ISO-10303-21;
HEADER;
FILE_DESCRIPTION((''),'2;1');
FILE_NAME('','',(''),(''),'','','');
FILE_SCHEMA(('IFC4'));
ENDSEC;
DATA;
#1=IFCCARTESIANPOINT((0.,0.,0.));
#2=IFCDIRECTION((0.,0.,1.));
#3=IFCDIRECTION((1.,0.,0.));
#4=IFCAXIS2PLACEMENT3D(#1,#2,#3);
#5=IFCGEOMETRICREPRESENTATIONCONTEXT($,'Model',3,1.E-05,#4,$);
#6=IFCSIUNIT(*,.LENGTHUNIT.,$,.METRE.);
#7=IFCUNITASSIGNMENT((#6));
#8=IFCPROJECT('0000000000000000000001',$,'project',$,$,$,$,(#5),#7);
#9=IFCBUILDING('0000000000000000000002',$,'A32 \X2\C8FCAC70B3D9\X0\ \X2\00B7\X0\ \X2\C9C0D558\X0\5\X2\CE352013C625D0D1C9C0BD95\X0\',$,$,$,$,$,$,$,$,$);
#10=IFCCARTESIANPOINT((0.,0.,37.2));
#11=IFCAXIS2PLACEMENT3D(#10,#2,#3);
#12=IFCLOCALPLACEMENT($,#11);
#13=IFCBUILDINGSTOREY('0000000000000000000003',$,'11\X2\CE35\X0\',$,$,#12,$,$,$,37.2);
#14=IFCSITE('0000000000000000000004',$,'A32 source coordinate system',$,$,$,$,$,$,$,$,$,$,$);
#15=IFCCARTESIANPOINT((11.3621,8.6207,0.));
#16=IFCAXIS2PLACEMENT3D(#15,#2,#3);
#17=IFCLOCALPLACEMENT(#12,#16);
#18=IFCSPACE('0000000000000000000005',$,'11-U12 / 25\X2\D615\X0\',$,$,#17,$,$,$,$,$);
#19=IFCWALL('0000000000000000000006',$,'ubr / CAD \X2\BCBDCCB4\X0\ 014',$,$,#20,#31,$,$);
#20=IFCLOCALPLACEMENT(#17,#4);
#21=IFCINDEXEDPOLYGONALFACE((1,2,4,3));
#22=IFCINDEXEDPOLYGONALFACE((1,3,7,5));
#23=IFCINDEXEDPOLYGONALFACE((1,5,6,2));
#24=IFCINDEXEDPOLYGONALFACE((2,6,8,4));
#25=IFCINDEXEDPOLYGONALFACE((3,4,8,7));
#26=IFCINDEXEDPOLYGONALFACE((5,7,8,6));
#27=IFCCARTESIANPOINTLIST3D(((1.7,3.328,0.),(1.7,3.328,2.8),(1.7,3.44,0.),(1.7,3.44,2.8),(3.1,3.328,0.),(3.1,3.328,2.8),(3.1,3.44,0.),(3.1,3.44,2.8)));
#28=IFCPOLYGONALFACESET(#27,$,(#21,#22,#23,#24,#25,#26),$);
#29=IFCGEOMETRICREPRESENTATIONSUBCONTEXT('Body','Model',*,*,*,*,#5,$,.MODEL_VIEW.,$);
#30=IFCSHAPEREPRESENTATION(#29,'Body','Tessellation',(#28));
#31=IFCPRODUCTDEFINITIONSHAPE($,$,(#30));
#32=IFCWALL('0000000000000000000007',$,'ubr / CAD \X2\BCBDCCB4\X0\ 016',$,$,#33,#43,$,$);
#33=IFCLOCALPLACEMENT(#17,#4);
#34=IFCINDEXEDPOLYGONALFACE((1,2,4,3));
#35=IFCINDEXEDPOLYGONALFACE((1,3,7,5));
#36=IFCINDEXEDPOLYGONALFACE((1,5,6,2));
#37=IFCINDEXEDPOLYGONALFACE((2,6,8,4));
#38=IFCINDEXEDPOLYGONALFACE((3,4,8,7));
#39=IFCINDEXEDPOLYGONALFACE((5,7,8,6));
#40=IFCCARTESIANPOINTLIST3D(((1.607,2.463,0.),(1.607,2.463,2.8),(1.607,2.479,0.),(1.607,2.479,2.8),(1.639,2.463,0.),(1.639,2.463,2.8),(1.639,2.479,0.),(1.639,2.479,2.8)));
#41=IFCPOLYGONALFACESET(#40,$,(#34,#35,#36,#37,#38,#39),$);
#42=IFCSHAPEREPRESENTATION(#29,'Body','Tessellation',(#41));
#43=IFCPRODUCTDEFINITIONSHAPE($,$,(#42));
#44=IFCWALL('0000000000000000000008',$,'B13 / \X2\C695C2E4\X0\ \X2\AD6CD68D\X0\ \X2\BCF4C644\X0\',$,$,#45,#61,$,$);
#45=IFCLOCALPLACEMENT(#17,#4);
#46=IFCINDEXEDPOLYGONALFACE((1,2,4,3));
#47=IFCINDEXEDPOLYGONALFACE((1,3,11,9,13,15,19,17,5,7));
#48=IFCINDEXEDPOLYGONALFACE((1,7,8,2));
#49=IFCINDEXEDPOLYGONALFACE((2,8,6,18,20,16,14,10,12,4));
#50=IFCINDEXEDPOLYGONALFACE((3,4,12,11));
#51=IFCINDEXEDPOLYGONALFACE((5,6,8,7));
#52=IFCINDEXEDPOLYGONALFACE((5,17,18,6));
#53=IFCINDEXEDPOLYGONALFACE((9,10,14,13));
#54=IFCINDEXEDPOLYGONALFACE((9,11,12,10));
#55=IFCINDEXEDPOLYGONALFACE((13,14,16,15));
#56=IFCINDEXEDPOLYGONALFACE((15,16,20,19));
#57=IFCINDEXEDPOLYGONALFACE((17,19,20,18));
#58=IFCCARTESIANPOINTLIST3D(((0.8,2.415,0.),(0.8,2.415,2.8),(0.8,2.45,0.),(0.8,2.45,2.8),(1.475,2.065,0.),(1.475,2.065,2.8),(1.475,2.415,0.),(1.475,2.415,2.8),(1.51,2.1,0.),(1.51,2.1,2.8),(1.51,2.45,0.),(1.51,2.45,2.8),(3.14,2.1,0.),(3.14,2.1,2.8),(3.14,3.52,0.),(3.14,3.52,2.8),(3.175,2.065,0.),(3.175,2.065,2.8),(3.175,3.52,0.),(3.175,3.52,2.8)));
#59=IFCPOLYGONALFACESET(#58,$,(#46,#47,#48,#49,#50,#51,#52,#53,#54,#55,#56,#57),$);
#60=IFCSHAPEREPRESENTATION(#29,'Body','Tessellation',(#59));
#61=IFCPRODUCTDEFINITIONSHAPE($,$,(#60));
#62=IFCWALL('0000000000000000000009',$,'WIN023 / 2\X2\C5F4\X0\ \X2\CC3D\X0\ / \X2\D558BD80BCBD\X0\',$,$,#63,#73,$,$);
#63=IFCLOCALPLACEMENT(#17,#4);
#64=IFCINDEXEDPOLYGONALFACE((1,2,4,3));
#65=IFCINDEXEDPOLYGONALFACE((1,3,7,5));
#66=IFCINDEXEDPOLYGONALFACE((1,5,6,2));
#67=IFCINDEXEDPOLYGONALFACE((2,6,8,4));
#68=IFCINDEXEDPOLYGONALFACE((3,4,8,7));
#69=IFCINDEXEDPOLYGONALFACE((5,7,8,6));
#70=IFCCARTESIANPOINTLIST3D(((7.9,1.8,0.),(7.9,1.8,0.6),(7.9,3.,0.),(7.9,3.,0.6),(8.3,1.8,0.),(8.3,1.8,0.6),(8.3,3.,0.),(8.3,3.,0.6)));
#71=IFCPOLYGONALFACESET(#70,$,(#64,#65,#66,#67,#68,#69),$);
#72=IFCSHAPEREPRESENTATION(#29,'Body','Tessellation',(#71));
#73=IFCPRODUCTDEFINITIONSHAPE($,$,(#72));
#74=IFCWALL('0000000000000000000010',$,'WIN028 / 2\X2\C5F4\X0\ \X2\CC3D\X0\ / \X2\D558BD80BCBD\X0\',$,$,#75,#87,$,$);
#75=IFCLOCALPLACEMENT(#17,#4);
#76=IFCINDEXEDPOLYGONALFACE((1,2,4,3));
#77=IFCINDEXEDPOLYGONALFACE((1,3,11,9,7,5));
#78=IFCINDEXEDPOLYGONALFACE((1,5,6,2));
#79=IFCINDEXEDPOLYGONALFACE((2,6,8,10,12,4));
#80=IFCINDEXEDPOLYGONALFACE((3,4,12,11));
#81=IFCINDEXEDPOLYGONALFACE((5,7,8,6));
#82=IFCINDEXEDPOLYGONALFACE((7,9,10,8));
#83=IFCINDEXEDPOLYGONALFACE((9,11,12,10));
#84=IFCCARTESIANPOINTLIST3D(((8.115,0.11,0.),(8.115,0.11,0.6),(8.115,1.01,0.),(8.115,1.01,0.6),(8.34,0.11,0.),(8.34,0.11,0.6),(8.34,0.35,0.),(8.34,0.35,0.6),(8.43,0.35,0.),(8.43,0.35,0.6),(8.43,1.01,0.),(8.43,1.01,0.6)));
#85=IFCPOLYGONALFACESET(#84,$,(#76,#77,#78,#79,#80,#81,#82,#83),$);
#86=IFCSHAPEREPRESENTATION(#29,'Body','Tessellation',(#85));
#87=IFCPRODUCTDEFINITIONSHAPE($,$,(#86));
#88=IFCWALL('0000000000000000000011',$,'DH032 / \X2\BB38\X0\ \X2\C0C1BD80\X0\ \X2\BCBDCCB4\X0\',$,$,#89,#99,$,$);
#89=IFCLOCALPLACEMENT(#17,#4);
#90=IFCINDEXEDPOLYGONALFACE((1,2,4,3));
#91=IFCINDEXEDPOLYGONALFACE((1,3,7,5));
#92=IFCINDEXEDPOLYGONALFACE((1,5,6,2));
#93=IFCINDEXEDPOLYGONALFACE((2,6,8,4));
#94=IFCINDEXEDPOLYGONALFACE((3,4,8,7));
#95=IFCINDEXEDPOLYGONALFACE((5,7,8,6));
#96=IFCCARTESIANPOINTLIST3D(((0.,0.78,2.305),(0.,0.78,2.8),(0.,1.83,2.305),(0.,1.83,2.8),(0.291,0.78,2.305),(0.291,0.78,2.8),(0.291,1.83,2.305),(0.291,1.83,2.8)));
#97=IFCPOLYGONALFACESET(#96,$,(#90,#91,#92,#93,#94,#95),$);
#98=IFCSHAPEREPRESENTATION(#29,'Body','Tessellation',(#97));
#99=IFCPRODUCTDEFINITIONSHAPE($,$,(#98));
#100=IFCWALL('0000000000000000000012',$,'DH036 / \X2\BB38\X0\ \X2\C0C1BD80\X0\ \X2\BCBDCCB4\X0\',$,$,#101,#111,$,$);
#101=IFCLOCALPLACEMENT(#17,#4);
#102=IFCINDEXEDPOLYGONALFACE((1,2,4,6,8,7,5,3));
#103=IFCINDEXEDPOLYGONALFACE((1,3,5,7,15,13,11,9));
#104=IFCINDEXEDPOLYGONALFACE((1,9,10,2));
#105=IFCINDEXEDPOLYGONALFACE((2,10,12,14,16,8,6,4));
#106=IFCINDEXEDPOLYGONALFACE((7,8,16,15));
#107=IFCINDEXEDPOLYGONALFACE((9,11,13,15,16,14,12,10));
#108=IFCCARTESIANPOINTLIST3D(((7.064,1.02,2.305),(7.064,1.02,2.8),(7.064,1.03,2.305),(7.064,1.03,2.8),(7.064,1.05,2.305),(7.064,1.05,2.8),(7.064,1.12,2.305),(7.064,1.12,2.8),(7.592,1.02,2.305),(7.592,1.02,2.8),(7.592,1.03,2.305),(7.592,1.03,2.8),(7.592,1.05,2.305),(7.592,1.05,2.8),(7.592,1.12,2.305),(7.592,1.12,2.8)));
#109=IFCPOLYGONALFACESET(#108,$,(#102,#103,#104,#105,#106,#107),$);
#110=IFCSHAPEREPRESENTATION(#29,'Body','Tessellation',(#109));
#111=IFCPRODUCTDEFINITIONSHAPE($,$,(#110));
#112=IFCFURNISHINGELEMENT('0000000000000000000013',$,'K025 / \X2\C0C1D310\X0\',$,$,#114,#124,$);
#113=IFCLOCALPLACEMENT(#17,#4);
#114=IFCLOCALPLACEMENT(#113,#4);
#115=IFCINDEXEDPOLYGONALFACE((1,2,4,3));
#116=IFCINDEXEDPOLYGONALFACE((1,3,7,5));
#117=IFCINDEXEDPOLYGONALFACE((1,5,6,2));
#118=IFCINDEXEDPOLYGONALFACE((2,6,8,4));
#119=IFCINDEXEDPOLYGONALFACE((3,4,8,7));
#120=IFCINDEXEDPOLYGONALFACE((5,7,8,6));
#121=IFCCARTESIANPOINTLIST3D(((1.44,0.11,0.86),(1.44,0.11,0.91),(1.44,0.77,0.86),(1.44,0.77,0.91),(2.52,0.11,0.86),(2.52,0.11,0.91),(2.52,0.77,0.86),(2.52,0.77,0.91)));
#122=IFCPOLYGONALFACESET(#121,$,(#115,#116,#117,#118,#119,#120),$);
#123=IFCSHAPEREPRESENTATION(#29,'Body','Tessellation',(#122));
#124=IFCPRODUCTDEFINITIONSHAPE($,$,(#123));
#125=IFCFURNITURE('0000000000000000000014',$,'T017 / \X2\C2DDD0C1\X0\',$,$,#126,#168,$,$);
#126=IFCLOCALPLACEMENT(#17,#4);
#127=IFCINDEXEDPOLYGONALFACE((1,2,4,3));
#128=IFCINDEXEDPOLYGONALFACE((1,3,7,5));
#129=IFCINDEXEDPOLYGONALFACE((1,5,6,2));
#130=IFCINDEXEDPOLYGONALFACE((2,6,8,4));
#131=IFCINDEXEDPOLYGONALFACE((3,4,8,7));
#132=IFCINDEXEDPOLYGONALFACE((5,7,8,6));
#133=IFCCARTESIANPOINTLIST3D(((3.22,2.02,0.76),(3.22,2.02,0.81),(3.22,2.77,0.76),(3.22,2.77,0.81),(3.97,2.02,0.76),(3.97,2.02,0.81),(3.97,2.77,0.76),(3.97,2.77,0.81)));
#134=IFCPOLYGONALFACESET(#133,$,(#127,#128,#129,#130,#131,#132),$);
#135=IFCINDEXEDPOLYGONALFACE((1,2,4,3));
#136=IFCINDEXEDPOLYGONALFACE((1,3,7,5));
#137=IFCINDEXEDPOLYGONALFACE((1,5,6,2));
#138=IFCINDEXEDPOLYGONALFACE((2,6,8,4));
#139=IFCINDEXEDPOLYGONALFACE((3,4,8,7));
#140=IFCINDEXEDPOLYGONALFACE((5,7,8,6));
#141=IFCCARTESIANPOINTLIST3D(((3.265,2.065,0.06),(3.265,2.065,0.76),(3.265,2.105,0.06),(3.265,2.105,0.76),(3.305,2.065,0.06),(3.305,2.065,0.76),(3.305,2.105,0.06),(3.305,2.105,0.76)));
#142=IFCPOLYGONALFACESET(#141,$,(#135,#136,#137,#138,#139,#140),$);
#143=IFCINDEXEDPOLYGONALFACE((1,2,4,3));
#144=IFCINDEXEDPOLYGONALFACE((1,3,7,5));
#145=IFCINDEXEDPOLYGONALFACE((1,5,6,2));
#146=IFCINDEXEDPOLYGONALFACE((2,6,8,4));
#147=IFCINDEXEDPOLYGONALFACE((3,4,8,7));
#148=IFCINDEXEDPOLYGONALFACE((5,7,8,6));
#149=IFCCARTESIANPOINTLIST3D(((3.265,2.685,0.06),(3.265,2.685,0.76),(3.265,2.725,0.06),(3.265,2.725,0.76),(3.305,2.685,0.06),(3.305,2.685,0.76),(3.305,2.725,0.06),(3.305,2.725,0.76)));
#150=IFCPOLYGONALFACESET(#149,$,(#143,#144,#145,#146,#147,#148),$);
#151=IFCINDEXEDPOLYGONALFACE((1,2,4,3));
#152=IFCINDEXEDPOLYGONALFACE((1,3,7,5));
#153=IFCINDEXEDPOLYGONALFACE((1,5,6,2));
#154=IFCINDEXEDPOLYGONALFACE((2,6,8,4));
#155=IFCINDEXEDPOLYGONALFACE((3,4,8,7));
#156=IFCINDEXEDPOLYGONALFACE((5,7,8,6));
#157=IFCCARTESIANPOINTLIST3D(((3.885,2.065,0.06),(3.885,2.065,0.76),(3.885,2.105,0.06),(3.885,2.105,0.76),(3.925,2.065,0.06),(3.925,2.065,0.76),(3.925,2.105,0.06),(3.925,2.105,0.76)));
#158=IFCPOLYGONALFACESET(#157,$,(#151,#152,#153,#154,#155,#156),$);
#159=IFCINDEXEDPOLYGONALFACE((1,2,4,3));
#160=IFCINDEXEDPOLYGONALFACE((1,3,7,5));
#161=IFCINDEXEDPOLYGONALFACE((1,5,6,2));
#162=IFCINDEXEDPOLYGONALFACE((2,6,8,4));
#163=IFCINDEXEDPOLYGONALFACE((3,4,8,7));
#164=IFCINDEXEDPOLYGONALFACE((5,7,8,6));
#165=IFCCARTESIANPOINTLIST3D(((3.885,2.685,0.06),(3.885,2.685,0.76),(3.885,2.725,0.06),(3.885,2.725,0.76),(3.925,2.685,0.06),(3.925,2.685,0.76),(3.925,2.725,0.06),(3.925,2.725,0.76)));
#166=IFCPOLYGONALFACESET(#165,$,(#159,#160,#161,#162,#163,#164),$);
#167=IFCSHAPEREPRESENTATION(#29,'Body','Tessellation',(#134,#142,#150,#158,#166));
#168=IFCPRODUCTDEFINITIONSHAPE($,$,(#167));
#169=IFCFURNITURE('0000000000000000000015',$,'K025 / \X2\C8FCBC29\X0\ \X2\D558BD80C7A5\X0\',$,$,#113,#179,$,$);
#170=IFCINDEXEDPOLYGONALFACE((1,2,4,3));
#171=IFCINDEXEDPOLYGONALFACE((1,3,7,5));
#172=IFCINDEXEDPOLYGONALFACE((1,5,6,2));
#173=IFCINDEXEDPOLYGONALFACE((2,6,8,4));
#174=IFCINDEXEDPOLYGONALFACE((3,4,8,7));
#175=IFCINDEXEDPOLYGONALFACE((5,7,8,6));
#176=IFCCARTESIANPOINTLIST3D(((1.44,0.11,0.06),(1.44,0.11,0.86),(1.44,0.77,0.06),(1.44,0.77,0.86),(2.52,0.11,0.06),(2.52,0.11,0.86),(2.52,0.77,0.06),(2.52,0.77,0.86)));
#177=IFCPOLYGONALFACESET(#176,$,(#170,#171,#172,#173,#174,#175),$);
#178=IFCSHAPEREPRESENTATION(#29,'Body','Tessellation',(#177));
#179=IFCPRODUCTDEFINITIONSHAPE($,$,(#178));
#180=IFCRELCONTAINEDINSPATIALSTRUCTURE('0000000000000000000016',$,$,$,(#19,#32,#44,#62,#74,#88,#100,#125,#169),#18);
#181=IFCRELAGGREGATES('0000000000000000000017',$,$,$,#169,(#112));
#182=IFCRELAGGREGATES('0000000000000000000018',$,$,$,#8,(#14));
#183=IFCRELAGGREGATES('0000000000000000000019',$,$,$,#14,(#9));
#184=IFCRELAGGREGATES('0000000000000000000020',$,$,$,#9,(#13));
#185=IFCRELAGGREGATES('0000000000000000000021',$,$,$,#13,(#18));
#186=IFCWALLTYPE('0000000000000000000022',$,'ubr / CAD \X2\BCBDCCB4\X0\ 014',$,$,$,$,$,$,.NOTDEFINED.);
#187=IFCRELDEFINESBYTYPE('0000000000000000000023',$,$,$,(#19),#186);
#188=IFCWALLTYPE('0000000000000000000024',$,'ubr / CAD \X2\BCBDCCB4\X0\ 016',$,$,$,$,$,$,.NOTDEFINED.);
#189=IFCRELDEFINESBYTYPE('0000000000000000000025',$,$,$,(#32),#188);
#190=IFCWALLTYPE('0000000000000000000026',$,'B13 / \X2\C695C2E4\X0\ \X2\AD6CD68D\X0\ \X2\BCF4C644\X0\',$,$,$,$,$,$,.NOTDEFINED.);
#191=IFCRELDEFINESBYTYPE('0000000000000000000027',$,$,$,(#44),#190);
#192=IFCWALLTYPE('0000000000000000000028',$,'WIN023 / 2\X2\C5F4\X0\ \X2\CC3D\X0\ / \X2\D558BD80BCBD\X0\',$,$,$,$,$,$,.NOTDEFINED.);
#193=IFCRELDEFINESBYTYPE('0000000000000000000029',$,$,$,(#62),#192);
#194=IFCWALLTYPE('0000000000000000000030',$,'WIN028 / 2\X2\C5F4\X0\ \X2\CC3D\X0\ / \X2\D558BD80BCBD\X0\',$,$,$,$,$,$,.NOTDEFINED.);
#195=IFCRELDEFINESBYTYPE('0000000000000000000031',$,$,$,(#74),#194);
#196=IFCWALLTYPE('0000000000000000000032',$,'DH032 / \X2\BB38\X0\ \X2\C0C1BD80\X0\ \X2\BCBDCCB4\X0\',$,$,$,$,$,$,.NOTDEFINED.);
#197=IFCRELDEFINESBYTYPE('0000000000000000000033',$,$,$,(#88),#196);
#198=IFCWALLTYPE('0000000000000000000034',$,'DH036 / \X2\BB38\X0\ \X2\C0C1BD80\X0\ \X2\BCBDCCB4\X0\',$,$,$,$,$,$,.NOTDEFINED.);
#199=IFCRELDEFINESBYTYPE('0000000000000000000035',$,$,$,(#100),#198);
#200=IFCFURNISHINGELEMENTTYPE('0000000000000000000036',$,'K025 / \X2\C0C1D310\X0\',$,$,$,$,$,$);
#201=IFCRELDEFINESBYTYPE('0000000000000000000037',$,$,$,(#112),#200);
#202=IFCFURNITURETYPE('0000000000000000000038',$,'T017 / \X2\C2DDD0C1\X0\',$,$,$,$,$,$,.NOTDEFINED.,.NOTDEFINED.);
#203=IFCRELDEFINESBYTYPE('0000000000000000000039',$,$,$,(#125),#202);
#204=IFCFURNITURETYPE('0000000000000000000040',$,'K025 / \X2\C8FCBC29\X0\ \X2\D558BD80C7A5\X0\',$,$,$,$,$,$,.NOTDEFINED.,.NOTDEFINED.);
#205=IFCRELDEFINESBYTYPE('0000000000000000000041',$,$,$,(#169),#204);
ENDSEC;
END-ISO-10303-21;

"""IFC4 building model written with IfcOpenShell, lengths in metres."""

from ifc_helpers import new_model, si_unit, frame, origin, origin_with_axes, place, context, subcontext, project, spatial, polyline, outline, extrude, source, transform, mapped, type_object, type_shapes, element, aggregate, save


model = new_model("IFC4")

# Units and contexts
model_context = context("Model", 3, precision=1e-05, world=origin_with_axes())
body_context = subcontext(model_context, "Body", "Model", "MODEL_VIEW")
ifc_project = project(units=[si_unit("LENGTHUNIT", "METRE")], contexts=[model_context])

# Site, building, storey, space
site = spatial("IfcSite", under=ifc_project, Name="A32 source coordinate system")
building = spatial("IfcBuilding", under=site, Name="A32 주거동 · 지하5층–옥탑지붕")
storey_placement = place(None, frame((0.0, 0.0, 37.2), z_axis=(0.0, 0.0, 1.0), x_axis=(1.0, 0.0, 0.0)))
storey = spatial("IfcBuildingStorey", under=building, at=storey_placement, Name="11층", Elevation=37.2)
space_1_placement = place(storey_placement, frame((11.3621, 8.6207, 0.0), z_axis=(0.0, 0.0, 1.0), x_axis=(1.0, 0.0, 0.0)))
space_1 = spatial("IfcSpace", under=storey, at=space_1_placement, Name="11-U12 / 25형")

# Walls
wall_type_1 = type_object("IfcWallType", Name="ubr / CAD 벽체 014", PredefinedType="NOTDEFINED")
shared_shape_1 = source(origin(), body_context, "Body", "SweptSolid", [
    extrude(outline(polyline([(3.1, 3.44), (3.1, 3.328), (1.7, 3.328), (1.7, 3.44), (3.1, 3.44)])), origin(), (0.0, 0.0, 1.0), 2.8),
])
type_shapes(wall_type_1, [shared_shape_1])
wall_1_placement = place(space_1_placement, origin_with_axes())
element("IfcWall", 1, at=wall_1_placement, inside=space_1, type_object=wall_type_1, Name="ubr / CAD 벽체 014", context=body_context, shape_type="MappedRepresentation", body=[
    mapped(shared_shape_1, transform((0.0, 0.0, 0.0), scale=1.0)),
])
wall_type_2 = type_object("IfcWallType", Name="ubr / CAD 벽체 016", PredefinedType="NOTDEFINED")
shared_shape_2 = source(origin(), body_context, "Body", "SweptSolid", [
    extrude(outline(polyline([(1.639, 2.479), (1.639, 2.463), (1.607, 2.463), (1.607, 2.479), (1.639, 2.479)])), origin(), (0.0, 0.0, 1.0), 2.8),
])
type_shapes(wall_type_2, [shared_shape_2])
wall_2_placement = place(space_1_placement, origin_with_axes())
element("IfcWall", 2, at=wall_2_placement, inside=space_1, type_object=wall_type_2, Name="ubr / CAD 벽체 016", context=body_context, shape_type="MappedRepresentation", body=[
    mapped(shared_shape_2, transform((0.0, 0.0, 0.0), scale=1.0)),
])
wall_type_3 = type_object("IfcWallType", Name="B13 / 욕실 구획 보완", PredefinedType="NOTDEFINED")
shared_shape_3 = source(origin(), body_context, "Body", "SweptSolid", [
    extrude(outline(polyline([(0.8, 2.45), (1.51, 2.45), (1.51, 2.1), (3.14, 2.1), (3.14, 3.52), (3.175, 3.52), (3.175, 2.065), (1.475, 2.065), (1.475, 2.415), (0.8, 2.415), (0.8, 2.45)])), origin(), (0.0, 0.0, 1.0), 2.8),
])
type_shapes(wall_type_3, [shared_shape_3])
wall_3_placement = place(space_1_placement, origin_with_axes())
element("IfcWall", 3, at=wall_3_placement, inside=space_1, type_object=wall_type_3, Name="B13 / 욕실 구획 보완", context=body_context, shape_type="MappedRepresentation", body=[
    mapped(shared_shape_3, transform((0.0, 0.0, 0.0), scale=1.0)),
])
wall_type_4 = type_object("IfcWallType", Name="WIN023 / 2열 창 / 하부벽", PredefinedType="NOTDEFINED")
shared_shape_4 = source(origin(), body_context, "Body", "SweptSolid", [
    extrude(outline(polyline([(7.9, 1.8), (7.9, 3.0), (8.3, 3.0), (8.3, 1.8), (7.9, 1.8)])), origin(), (0.0, 0.0, 1.0), 0.6),
])
type_shapes(wall_type_4, [shared_shape_4])
wall_4_placement = place(space_1_placement, origin_with_axes())
element("IfcWall", 4, at=wall_4_placement, inside=space_1, type_object=wall_type_4, Name="WIN023 / 2열 창 / 하부벽", context=body_context, shape_type="MappedRepresentation", body=[
    mapped(shared_shape_4, transform((0.0, 0.0, 0.0), scale=1.0)),
])
wall_type_5 = type_object("IfcWallType", Name="WIN028 / 2열 창 / 하부벽", PredefinedType="NOTDEFINED")
shared_shape_5 = source(origin(), body_context, "Body", "SweptSolid", [
    extrude(outline(polyline([(8.34, 0.35), (8.34, 0.11), (8.115, 0.11), (8.115, 1.01), (8.43, 1.01), (8.43, 0.35), (8.34, 0.35)])), origin(), (0.0, 0.0, 1.0), 0.6),
])
type_shapes(wall_type_5, [shared_shape_5])
wall_5_placement = place(space_1_placement, origin_with_axes())
element("IfcWall", 5, at=wall_5_placement, inside=space_1, type_object=wall_type_5, Name="WIN028 / 2열 창 / 하부벽", context=body_context, shape_type="MappedRepresentation", body=[
    mapped(shared_shape_5, transform((0.0, 0.0, 0.0), scale=1.0)),
])
wall_type_6 = type_object("IfcWallType", Name="DH032 / 문 상부 벽체", PredefinedType="NOTDEFINED")
shared_shape_6 = source(origin(), body_context, "Body", "SweptSolid", [
    extrude(outline(polyline([(0.0, 1.83), (0.291, 1.83), (0.291, 0.78), (0.0, 0.78), (0.0, 1.83)])), frame((0.0, 0.0, 2.305)), (0.0, 0.0, 1.0), 0.495),
])
type_shapes(wall_type_6, [shared_shape_6])
wall_6_placement = place(space_1_placement, origin_with_axes())
element("IfcWall", 6, at=wall_6_placement, inside=space_1, type_object=wall_type_6, Name="DH032 / 문 상부 벽체", context=body_context, shape_type="MappedRepresentation", body=[
    mapped(shared_shape_6, transform((0.0, 0.0, 0.0), scale=1.0)),
])
wall_type_7 = type_object("IfcWallType", Name="DH036 / 문 상부 벽체", PredefinedType="NOTDEFINED")
shared_shape_7 = source(origin(), body_context, "Body", "SweptSolid", [
    extrude(outline(polyline([(7.064, 1.03), (7.064, 1.05), (7.064, 1.12), (7.592, 1.12), (7.592, 1.05), (7.592, 1.03), (7.592, 1.02), (7.064, 1.02), (7.064, 1.03)])), frame((0.0, 0.0, 2.305)), (0.0, 0.0, 1.0), 0.495),
])
type_shapes(wall_type_7, [shared_shape_7])
wall_7_placement = place(space_1_placement, origin_with_axes())
element("IfcWall", 7, at=wall_7_placement, inside=space_1, type_object=wall_type_7, Name="DH036 / 문 상부 벽체", context=body_context, shape_type="MappedRepresentation", body=[
    mapped(shared_shape_7, transform((0.0, 0.0, 0.0), scale=1.0)),
])

# Furnishing element
furnishing_element_type_1 = type_object("IfcFurnishingElementType", Name="K025 / 상판")
shared_shape_8 = source(origin(), body_context, "Body", "SweptSolid", [
    extrude(outline(polyline([(2.52, 0.77), (2.52, 0.11), (1.44, 0.11), (1.44, 0.77), (2.52, 0.77)])), frame((0.0, 0.0, 0.86)), (0.0, 0.0, 1.0), 0.05),
])
type_shapes(furnishing_element_type_1, [shared_shape_8])
furniture_1_placement = place(space_1_placement, origin_with_axes())
furnishing_1_placement = place(furniture_1_placement, origin_with_axes())
furnishing_1 = element("IfcFurnishingElement", 8, at=furnishing_1_placement, type_object=furnishing_element_type_1, Name="K025 / 상판", context=body_context, shape_type="MappedRepresentation", body=[
    mapped(shared_shape_8, transform((0.0, 0.0, 0.0), scale=1.0)),
])

# Furniture
furniture_type_1 = type_object("IfcFurnitureType", Name="T017 / 식탁", AssemblyPlace="NOTDEFINED", PredefinedType="NOTDEFINED")
shared_shape_9 = source(origin(), body_context, "Body", "SweptSolid", [
    extrude(outline(polyline([(3.97, 2.02), (3.22, 2.02), (3.22, 2.77), (3.97, 2.77), (3.97, 2.02)])), frame((0.0, 0.0, 0.76)), (0.0, 0.0, 1.0), 0.05),
    extrude(outline(polyline([(3.265, 2.065), (3.265, 2.105), (3.305, 2.105), (3.305, 2.065), (3.265, 2.065)])), frame((0.0, 0.0, 0.06)), (0.0, 0.0, 1.0), 0.7),
    extrude(outline(polyline([(3.265, 2.685), (3.265, 2.725), (3.305, 2.725), (3.305, 2.685), (3.265, 2.685)])), frame((0.0, 0.0, 0.06)), (0.0, 0.0, 1.0), 0.7),
    extrude(outline(polyline([(3.885, 2.065), (3.885, 2.105), (3.925, 2.105), (3.925, 2.065), (3.885, 2.065)])), frame((0.0, 0.0, 0.06)), (0.0, 0.0, 1.0), 0.7),
    extrude(outline(polyline([(3.885, 2.685), (3.885, 2.725), (3.925, 2.725), (3.925, 2.685), (3.885, 2.685)])), frame((0.0, 0.0, 0.06)), (0.0, 0.0, 1.0), 0.7),
])
type_shapes(furniture_type_1, [shared_shape_9])
furniture_2_placement = place(space_1_placement, origin_with_axes())
element("IfcFurniture", 9, at=furniture_2_placement, inside=space_1, type_object=furniture_type_1, Name="T017 / 식탁", context=body_context, shape_type="MappedRepresentation", body=[
    mapped(shared_shape_9, transform((0.0, 0.0, 0.0), scale=1.0)),
])
furniture_type_2 = type_object("IfcFurnitureType", Name="K025 / 주방 하부장", AssemblyPlace="NOTDEFINED", PredefinedType="NOTDEFINED")
shared_shape_10 = source(origin(), body_context, "Body", "SweptSolid", [
    extrude(outline(polyline([(1.44, 0.77), (2.52, 0.77), (2.52, 0.11), (1.44, 0.11), (1.44, 0.77)])), frame((0.0, 0.0, 0.06)), (0.0, 0.0, 1.0), 0.8),
])
type_shapes(furniture_type_2, [shared_shape_10])
furniture_1 = element("IfcFurniture", 10, at=furniture_1_placement, inside=space_1, type_object=furniture_type_2, Name="K025 / 주방 하부장", context=body_context, shape_type="MappedRepresentation", body=[
    mapped(shared_shape_10, transform((0.0, 0.0, 0.0), scale=1.0)),
])
aggregate(furniture_1, [furnishing_1])

save(model, "model.ifc")
